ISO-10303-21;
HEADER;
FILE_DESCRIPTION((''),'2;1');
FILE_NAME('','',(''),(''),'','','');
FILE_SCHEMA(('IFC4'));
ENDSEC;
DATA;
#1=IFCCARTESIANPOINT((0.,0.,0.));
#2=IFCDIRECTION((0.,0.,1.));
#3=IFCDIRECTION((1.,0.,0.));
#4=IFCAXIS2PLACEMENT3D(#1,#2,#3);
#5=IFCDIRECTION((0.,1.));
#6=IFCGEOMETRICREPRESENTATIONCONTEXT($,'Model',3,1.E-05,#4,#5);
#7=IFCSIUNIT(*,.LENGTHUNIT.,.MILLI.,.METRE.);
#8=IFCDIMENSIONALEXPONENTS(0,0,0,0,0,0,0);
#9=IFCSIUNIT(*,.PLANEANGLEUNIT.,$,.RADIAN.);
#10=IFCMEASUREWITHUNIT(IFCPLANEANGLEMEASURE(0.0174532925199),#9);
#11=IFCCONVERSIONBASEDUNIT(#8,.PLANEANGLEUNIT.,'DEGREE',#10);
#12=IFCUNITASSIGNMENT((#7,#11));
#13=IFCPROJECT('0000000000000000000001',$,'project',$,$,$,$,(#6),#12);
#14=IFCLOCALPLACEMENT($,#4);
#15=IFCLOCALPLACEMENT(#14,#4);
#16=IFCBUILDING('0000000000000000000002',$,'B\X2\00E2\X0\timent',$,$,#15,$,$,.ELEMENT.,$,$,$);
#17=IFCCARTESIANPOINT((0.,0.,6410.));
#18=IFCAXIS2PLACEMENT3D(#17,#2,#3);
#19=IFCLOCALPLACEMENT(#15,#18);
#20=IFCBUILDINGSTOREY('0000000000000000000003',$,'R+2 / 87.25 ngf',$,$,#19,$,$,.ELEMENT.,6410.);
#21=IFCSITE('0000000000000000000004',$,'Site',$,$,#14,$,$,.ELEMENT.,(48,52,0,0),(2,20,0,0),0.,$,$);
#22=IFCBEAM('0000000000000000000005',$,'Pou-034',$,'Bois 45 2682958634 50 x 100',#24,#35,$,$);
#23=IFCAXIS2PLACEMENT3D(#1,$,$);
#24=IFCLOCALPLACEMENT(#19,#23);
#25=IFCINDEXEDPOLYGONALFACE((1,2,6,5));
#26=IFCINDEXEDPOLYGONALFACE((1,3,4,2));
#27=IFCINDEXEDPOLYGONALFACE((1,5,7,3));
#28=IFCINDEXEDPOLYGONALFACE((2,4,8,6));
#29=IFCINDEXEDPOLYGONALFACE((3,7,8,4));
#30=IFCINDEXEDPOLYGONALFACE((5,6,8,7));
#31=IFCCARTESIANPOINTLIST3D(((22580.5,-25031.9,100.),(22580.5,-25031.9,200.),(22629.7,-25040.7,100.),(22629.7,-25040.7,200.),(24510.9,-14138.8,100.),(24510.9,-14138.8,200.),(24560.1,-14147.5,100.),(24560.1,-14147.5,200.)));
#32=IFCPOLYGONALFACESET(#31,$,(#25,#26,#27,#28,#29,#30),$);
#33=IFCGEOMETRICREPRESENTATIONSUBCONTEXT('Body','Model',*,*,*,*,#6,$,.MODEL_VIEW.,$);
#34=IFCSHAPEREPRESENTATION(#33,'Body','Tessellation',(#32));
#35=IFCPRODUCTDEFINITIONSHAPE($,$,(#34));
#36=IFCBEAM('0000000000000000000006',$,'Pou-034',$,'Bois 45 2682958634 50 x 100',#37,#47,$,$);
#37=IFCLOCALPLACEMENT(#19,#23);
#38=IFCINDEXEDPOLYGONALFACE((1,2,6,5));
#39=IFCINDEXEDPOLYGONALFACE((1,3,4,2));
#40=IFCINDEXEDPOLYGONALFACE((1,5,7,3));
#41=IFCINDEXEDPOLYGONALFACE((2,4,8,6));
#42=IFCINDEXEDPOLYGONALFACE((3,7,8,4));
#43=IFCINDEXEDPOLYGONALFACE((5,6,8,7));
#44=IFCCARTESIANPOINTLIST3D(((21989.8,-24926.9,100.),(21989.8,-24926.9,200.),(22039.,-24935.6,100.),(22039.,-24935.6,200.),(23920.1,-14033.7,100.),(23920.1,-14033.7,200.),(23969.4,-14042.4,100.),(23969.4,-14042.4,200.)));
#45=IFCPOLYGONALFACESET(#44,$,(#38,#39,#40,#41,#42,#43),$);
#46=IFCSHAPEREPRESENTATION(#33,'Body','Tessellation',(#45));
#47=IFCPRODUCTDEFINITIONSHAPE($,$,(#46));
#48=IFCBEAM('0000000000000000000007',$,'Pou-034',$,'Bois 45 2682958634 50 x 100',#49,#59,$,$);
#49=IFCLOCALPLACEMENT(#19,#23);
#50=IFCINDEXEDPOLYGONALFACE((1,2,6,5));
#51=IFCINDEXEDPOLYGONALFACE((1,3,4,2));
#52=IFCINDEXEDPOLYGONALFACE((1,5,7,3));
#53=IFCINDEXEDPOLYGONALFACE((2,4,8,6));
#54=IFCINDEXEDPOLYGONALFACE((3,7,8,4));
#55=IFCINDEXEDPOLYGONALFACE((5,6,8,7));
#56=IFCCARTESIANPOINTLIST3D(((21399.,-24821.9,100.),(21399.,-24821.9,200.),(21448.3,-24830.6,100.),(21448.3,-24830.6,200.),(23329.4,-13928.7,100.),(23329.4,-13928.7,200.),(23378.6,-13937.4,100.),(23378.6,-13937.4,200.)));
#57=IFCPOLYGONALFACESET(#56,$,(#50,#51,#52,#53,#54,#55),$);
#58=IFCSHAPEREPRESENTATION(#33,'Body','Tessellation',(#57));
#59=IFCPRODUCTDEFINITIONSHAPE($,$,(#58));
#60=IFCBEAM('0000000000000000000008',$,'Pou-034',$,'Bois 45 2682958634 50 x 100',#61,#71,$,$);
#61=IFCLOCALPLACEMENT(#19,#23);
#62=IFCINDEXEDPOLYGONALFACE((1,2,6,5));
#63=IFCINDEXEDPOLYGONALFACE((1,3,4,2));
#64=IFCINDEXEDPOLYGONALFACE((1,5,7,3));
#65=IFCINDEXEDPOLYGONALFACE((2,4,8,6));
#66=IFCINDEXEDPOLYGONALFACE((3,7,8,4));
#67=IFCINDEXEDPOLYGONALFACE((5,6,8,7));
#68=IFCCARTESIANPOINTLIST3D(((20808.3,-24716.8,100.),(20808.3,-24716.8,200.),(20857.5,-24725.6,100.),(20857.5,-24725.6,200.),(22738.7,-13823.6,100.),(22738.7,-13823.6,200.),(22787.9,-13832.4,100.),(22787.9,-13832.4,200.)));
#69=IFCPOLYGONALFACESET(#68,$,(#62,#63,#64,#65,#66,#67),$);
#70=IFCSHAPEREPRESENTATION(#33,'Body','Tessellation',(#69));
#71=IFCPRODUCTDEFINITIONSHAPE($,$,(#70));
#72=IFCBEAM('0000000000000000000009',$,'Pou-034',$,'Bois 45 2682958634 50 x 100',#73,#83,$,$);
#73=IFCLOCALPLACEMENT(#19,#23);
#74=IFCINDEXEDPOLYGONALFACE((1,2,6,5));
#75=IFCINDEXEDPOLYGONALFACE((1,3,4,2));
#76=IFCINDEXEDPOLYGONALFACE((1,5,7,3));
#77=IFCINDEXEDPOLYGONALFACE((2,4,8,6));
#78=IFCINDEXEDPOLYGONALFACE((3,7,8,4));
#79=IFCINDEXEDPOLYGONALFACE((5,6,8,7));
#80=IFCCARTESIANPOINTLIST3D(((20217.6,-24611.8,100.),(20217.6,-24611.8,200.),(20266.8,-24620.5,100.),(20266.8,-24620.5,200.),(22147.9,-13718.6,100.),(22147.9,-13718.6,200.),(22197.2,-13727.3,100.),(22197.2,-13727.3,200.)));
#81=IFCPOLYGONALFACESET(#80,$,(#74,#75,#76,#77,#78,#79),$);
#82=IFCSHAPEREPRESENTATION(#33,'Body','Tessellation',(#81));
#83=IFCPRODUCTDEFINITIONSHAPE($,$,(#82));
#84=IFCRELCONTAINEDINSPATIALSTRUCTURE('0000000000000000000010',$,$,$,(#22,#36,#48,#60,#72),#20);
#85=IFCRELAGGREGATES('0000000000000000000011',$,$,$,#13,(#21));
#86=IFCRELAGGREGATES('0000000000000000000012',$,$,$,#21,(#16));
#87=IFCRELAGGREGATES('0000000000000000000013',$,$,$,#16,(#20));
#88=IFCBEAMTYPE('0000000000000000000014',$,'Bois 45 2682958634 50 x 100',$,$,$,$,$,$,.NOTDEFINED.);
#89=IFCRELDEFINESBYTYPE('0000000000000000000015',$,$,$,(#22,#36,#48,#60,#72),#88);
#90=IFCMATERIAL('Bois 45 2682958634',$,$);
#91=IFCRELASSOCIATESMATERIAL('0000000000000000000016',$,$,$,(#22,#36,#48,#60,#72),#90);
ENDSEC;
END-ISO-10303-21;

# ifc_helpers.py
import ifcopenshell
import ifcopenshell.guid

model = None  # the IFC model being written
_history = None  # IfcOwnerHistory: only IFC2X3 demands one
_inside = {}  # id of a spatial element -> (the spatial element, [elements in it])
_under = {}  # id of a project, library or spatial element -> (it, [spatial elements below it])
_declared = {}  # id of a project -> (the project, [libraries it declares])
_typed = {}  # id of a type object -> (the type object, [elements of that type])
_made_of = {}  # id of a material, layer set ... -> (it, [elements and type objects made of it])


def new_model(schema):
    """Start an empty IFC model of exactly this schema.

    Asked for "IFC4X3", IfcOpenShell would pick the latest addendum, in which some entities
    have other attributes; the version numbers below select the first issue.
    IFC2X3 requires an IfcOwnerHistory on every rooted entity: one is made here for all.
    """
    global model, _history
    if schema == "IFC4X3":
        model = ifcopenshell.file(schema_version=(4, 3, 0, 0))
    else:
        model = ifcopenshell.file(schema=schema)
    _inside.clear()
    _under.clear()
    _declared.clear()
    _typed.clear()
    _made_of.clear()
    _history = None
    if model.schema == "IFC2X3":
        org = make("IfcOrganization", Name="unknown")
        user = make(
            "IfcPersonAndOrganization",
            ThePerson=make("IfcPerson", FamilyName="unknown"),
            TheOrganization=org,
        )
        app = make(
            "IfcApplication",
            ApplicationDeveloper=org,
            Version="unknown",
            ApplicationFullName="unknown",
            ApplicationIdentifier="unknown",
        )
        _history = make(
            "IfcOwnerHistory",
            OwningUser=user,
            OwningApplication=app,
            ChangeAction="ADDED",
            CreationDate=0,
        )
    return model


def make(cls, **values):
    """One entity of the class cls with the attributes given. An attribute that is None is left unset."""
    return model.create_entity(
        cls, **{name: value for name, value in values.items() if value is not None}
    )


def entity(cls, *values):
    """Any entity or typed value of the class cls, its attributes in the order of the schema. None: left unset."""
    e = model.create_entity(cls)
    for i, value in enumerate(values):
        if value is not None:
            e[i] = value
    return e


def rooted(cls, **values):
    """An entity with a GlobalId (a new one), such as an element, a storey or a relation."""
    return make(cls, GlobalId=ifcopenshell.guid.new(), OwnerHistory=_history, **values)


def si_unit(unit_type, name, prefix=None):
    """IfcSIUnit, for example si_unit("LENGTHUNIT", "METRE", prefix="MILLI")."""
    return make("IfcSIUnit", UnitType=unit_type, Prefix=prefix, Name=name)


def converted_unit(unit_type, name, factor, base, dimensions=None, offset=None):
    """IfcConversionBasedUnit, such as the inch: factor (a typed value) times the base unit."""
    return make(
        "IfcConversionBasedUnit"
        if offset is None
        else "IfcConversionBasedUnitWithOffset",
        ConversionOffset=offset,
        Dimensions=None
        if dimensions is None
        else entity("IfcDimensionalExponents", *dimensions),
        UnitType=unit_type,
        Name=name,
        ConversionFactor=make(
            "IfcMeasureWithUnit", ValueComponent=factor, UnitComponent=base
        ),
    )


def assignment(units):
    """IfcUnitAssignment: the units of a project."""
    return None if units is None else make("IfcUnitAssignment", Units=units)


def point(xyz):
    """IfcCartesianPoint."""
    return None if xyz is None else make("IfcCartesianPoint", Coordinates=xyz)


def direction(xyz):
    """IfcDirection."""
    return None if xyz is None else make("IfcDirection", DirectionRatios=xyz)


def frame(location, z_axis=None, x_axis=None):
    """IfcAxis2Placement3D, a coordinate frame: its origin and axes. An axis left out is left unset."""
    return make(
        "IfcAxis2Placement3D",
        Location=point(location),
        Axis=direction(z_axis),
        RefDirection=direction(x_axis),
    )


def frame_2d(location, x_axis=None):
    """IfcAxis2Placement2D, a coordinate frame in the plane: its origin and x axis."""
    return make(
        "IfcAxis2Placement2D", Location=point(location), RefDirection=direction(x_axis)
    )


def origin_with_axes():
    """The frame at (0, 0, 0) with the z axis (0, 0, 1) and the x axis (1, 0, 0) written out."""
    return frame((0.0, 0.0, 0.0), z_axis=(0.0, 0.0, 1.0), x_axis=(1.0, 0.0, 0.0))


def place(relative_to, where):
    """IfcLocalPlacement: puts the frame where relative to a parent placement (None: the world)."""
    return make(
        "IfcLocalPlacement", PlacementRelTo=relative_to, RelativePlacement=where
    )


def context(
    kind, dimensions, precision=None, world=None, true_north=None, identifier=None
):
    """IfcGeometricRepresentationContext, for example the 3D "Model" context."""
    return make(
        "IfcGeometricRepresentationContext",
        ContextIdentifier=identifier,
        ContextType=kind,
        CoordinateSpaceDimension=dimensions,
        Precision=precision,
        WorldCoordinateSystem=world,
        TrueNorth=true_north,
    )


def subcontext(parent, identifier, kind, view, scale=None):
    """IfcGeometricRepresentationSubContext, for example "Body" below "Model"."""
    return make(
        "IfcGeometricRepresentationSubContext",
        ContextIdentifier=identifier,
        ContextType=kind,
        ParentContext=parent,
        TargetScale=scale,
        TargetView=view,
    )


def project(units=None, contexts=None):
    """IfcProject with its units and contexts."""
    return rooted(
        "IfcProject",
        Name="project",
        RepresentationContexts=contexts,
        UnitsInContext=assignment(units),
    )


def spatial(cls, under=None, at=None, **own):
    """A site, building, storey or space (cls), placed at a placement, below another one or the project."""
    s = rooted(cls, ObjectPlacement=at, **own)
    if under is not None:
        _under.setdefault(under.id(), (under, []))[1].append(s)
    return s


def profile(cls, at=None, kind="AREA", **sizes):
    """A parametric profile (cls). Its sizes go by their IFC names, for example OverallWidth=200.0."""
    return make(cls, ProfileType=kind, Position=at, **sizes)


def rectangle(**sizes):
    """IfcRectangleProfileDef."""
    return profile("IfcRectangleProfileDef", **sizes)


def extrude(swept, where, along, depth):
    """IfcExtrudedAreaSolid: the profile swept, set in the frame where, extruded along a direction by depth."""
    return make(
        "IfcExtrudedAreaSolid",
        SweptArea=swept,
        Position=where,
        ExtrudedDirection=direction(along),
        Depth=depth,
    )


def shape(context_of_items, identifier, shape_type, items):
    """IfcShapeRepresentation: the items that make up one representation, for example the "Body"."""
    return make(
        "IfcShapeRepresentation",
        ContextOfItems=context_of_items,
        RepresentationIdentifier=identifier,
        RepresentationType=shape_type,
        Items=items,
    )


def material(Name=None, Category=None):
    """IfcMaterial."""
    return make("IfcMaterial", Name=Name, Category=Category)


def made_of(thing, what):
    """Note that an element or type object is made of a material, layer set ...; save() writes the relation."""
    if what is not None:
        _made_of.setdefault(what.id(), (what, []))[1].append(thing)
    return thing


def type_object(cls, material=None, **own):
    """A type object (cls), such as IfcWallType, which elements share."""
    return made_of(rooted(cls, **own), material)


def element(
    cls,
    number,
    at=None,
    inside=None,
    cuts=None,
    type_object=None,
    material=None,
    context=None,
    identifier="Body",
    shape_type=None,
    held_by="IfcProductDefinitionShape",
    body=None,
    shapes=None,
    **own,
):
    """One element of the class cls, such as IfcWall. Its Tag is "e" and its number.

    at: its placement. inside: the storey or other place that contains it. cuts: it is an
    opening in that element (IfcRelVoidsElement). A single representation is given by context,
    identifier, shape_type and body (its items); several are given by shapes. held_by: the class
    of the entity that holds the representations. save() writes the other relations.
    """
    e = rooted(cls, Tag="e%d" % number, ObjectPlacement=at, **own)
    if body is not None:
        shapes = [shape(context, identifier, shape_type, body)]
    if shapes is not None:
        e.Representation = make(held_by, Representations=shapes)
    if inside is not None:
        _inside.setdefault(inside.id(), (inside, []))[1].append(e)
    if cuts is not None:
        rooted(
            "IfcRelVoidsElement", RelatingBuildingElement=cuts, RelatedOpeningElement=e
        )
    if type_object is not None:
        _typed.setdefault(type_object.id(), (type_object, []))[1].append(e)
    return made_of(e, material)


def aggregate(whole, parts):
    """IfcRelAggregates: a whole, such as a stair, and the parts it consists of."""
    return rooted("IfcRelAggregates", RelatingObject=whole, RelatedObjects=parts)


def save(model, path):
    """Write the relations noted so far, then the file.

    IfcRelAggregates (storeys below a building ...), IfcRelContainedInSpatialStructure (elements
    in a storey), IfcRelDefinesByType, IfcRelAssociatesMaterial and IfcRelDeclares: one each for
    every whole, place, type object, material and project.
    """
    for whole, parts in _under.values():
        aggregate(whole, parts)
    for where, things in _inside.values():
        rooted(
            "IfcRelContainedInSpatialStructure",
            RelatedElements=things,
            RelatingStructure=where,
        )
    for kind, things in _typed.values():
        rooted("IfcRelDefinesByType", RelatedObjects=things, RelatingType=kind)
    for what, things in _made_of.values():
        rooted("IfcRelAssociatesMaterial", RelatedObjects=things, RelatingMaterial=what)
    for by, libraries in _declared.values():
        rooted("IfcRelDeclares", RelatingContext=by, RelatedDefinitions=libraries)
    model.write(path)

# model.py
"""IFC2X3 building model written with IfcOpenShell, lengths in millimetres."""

from ifc_helpers import new_model, entity, si_unit, converted_unit, direction, frame, frame_2d, origin_with_axes, place, context, subcontext, project, spatial, rectangle, extrude, material, type_object, element, save


model = new_model("IFC2X3")

# Units and contexts
model_context = context("Model", 3, precision=1e-05, world=origin_with_axes(), true_north=direction((0.0, 1.0)))
body_context = subcontext(model_context, "Body", "Model", "MODEL_VIEW")
ifc_project = project(units=[si_unit("LENGTHUNIT", "METRE", prefix="MILLI"), converted_unit("PLANEANGLEUNIT", "DEGREE", entity("IfcPlaneAngleMeasure", 0.0174532925199), si_unit("PLANEANGLEUNIT", "RADIAN"), dimensions=[0, 0, 0, 0, 0, 0, 0])], contexts=[model_context])

# Site, building, storey
site_placement = place(None, origin_with_axes())
site = spatial("IfcSite", under=ifc_project, at=site_placement, Name="Site", CompositionType="ELEMENT", RefLatitude=(48, 52, 0, 0), RefLongitude=(2, 20, 0, 0), RefElevation=0.0)
building_placement = place(site_placement, origin_with_axes())
building = spatial("IfcBuilding", under=site, at=building_placement, Name="Bâtiment", CompositionType="ELEMENT")
storey_placement = place(building_placement, frame((0.0, 0.0, 6410.0), z_axis=(0.0, 0.0, 1.0), x_axis=(1.0, 0.0, 0.0)))
storey = spatial("IfcBuildingStorey", under=building, at=storey_placement, Name="R+2 / 87.25 ngf", CompositionType="ELEMENT", Elevation=6410.0)

# Beams
ifc_material_1 = material(Name="Bois 45 2682958634")
beam_type = type_object("IfcBeamType", Name="Bois 45 2682958634 50 x 100", PredefinedType="NOTDEFINED")
for number, where, z_axis, x_axis, name in (
    (1, (22605.1, -25036.3, 200.0), (0.0, 0.0, 1.0), (0.984659, -0.174492, 0.0), "Pou-034"),
    (2, (22014.4, -24931.3, 200.0), (0.0, 0.0, 1.0), (0.984659, -0.174492, 0.0), "Pou-034"),
    (3, (21423.6, -24826.2, 200.0), (0.0, 0.0, 1.0), (0.984659, -0.174492, 0.0), "Pou-034"),
    (4, (20832.9, -24721.2, 200.0), (0.0, 0.0, 1.0), (0.984659, -0.174492, 0.0), "Pou-034"),
    (5, (20242.2, -24616.2, 200.0), (0.0, 0.0, 1.0), (0.984659, -0.174492, 0.0), "Pou-034"),
):
    element("IfcBeam", number, at=place(storey_placement, frame(where, z_axis=z_axis, x_axis=x_axis)), inside=storey, type_object=beam_type, material=ifc_material_1, Name=name, ObjectType="Bois 45 2682958634 50 x 100", context=body_context, shape_type="SweptSolid", body=[
        extrude(rectangle(XDim=100.0, YDim=50.0, at=frame_2d((-50.0, 0.0), x_axis=(1.0, 0.0))), frame((0.0, 0.0, 0.0), z_axis=(0.0, 1.0, 0.0), x_axis=(0.0, 0.0, 1.0)), (0.0, 0.0, 1.0), 11062.9),
    ])

save(model, "model.ifc")
